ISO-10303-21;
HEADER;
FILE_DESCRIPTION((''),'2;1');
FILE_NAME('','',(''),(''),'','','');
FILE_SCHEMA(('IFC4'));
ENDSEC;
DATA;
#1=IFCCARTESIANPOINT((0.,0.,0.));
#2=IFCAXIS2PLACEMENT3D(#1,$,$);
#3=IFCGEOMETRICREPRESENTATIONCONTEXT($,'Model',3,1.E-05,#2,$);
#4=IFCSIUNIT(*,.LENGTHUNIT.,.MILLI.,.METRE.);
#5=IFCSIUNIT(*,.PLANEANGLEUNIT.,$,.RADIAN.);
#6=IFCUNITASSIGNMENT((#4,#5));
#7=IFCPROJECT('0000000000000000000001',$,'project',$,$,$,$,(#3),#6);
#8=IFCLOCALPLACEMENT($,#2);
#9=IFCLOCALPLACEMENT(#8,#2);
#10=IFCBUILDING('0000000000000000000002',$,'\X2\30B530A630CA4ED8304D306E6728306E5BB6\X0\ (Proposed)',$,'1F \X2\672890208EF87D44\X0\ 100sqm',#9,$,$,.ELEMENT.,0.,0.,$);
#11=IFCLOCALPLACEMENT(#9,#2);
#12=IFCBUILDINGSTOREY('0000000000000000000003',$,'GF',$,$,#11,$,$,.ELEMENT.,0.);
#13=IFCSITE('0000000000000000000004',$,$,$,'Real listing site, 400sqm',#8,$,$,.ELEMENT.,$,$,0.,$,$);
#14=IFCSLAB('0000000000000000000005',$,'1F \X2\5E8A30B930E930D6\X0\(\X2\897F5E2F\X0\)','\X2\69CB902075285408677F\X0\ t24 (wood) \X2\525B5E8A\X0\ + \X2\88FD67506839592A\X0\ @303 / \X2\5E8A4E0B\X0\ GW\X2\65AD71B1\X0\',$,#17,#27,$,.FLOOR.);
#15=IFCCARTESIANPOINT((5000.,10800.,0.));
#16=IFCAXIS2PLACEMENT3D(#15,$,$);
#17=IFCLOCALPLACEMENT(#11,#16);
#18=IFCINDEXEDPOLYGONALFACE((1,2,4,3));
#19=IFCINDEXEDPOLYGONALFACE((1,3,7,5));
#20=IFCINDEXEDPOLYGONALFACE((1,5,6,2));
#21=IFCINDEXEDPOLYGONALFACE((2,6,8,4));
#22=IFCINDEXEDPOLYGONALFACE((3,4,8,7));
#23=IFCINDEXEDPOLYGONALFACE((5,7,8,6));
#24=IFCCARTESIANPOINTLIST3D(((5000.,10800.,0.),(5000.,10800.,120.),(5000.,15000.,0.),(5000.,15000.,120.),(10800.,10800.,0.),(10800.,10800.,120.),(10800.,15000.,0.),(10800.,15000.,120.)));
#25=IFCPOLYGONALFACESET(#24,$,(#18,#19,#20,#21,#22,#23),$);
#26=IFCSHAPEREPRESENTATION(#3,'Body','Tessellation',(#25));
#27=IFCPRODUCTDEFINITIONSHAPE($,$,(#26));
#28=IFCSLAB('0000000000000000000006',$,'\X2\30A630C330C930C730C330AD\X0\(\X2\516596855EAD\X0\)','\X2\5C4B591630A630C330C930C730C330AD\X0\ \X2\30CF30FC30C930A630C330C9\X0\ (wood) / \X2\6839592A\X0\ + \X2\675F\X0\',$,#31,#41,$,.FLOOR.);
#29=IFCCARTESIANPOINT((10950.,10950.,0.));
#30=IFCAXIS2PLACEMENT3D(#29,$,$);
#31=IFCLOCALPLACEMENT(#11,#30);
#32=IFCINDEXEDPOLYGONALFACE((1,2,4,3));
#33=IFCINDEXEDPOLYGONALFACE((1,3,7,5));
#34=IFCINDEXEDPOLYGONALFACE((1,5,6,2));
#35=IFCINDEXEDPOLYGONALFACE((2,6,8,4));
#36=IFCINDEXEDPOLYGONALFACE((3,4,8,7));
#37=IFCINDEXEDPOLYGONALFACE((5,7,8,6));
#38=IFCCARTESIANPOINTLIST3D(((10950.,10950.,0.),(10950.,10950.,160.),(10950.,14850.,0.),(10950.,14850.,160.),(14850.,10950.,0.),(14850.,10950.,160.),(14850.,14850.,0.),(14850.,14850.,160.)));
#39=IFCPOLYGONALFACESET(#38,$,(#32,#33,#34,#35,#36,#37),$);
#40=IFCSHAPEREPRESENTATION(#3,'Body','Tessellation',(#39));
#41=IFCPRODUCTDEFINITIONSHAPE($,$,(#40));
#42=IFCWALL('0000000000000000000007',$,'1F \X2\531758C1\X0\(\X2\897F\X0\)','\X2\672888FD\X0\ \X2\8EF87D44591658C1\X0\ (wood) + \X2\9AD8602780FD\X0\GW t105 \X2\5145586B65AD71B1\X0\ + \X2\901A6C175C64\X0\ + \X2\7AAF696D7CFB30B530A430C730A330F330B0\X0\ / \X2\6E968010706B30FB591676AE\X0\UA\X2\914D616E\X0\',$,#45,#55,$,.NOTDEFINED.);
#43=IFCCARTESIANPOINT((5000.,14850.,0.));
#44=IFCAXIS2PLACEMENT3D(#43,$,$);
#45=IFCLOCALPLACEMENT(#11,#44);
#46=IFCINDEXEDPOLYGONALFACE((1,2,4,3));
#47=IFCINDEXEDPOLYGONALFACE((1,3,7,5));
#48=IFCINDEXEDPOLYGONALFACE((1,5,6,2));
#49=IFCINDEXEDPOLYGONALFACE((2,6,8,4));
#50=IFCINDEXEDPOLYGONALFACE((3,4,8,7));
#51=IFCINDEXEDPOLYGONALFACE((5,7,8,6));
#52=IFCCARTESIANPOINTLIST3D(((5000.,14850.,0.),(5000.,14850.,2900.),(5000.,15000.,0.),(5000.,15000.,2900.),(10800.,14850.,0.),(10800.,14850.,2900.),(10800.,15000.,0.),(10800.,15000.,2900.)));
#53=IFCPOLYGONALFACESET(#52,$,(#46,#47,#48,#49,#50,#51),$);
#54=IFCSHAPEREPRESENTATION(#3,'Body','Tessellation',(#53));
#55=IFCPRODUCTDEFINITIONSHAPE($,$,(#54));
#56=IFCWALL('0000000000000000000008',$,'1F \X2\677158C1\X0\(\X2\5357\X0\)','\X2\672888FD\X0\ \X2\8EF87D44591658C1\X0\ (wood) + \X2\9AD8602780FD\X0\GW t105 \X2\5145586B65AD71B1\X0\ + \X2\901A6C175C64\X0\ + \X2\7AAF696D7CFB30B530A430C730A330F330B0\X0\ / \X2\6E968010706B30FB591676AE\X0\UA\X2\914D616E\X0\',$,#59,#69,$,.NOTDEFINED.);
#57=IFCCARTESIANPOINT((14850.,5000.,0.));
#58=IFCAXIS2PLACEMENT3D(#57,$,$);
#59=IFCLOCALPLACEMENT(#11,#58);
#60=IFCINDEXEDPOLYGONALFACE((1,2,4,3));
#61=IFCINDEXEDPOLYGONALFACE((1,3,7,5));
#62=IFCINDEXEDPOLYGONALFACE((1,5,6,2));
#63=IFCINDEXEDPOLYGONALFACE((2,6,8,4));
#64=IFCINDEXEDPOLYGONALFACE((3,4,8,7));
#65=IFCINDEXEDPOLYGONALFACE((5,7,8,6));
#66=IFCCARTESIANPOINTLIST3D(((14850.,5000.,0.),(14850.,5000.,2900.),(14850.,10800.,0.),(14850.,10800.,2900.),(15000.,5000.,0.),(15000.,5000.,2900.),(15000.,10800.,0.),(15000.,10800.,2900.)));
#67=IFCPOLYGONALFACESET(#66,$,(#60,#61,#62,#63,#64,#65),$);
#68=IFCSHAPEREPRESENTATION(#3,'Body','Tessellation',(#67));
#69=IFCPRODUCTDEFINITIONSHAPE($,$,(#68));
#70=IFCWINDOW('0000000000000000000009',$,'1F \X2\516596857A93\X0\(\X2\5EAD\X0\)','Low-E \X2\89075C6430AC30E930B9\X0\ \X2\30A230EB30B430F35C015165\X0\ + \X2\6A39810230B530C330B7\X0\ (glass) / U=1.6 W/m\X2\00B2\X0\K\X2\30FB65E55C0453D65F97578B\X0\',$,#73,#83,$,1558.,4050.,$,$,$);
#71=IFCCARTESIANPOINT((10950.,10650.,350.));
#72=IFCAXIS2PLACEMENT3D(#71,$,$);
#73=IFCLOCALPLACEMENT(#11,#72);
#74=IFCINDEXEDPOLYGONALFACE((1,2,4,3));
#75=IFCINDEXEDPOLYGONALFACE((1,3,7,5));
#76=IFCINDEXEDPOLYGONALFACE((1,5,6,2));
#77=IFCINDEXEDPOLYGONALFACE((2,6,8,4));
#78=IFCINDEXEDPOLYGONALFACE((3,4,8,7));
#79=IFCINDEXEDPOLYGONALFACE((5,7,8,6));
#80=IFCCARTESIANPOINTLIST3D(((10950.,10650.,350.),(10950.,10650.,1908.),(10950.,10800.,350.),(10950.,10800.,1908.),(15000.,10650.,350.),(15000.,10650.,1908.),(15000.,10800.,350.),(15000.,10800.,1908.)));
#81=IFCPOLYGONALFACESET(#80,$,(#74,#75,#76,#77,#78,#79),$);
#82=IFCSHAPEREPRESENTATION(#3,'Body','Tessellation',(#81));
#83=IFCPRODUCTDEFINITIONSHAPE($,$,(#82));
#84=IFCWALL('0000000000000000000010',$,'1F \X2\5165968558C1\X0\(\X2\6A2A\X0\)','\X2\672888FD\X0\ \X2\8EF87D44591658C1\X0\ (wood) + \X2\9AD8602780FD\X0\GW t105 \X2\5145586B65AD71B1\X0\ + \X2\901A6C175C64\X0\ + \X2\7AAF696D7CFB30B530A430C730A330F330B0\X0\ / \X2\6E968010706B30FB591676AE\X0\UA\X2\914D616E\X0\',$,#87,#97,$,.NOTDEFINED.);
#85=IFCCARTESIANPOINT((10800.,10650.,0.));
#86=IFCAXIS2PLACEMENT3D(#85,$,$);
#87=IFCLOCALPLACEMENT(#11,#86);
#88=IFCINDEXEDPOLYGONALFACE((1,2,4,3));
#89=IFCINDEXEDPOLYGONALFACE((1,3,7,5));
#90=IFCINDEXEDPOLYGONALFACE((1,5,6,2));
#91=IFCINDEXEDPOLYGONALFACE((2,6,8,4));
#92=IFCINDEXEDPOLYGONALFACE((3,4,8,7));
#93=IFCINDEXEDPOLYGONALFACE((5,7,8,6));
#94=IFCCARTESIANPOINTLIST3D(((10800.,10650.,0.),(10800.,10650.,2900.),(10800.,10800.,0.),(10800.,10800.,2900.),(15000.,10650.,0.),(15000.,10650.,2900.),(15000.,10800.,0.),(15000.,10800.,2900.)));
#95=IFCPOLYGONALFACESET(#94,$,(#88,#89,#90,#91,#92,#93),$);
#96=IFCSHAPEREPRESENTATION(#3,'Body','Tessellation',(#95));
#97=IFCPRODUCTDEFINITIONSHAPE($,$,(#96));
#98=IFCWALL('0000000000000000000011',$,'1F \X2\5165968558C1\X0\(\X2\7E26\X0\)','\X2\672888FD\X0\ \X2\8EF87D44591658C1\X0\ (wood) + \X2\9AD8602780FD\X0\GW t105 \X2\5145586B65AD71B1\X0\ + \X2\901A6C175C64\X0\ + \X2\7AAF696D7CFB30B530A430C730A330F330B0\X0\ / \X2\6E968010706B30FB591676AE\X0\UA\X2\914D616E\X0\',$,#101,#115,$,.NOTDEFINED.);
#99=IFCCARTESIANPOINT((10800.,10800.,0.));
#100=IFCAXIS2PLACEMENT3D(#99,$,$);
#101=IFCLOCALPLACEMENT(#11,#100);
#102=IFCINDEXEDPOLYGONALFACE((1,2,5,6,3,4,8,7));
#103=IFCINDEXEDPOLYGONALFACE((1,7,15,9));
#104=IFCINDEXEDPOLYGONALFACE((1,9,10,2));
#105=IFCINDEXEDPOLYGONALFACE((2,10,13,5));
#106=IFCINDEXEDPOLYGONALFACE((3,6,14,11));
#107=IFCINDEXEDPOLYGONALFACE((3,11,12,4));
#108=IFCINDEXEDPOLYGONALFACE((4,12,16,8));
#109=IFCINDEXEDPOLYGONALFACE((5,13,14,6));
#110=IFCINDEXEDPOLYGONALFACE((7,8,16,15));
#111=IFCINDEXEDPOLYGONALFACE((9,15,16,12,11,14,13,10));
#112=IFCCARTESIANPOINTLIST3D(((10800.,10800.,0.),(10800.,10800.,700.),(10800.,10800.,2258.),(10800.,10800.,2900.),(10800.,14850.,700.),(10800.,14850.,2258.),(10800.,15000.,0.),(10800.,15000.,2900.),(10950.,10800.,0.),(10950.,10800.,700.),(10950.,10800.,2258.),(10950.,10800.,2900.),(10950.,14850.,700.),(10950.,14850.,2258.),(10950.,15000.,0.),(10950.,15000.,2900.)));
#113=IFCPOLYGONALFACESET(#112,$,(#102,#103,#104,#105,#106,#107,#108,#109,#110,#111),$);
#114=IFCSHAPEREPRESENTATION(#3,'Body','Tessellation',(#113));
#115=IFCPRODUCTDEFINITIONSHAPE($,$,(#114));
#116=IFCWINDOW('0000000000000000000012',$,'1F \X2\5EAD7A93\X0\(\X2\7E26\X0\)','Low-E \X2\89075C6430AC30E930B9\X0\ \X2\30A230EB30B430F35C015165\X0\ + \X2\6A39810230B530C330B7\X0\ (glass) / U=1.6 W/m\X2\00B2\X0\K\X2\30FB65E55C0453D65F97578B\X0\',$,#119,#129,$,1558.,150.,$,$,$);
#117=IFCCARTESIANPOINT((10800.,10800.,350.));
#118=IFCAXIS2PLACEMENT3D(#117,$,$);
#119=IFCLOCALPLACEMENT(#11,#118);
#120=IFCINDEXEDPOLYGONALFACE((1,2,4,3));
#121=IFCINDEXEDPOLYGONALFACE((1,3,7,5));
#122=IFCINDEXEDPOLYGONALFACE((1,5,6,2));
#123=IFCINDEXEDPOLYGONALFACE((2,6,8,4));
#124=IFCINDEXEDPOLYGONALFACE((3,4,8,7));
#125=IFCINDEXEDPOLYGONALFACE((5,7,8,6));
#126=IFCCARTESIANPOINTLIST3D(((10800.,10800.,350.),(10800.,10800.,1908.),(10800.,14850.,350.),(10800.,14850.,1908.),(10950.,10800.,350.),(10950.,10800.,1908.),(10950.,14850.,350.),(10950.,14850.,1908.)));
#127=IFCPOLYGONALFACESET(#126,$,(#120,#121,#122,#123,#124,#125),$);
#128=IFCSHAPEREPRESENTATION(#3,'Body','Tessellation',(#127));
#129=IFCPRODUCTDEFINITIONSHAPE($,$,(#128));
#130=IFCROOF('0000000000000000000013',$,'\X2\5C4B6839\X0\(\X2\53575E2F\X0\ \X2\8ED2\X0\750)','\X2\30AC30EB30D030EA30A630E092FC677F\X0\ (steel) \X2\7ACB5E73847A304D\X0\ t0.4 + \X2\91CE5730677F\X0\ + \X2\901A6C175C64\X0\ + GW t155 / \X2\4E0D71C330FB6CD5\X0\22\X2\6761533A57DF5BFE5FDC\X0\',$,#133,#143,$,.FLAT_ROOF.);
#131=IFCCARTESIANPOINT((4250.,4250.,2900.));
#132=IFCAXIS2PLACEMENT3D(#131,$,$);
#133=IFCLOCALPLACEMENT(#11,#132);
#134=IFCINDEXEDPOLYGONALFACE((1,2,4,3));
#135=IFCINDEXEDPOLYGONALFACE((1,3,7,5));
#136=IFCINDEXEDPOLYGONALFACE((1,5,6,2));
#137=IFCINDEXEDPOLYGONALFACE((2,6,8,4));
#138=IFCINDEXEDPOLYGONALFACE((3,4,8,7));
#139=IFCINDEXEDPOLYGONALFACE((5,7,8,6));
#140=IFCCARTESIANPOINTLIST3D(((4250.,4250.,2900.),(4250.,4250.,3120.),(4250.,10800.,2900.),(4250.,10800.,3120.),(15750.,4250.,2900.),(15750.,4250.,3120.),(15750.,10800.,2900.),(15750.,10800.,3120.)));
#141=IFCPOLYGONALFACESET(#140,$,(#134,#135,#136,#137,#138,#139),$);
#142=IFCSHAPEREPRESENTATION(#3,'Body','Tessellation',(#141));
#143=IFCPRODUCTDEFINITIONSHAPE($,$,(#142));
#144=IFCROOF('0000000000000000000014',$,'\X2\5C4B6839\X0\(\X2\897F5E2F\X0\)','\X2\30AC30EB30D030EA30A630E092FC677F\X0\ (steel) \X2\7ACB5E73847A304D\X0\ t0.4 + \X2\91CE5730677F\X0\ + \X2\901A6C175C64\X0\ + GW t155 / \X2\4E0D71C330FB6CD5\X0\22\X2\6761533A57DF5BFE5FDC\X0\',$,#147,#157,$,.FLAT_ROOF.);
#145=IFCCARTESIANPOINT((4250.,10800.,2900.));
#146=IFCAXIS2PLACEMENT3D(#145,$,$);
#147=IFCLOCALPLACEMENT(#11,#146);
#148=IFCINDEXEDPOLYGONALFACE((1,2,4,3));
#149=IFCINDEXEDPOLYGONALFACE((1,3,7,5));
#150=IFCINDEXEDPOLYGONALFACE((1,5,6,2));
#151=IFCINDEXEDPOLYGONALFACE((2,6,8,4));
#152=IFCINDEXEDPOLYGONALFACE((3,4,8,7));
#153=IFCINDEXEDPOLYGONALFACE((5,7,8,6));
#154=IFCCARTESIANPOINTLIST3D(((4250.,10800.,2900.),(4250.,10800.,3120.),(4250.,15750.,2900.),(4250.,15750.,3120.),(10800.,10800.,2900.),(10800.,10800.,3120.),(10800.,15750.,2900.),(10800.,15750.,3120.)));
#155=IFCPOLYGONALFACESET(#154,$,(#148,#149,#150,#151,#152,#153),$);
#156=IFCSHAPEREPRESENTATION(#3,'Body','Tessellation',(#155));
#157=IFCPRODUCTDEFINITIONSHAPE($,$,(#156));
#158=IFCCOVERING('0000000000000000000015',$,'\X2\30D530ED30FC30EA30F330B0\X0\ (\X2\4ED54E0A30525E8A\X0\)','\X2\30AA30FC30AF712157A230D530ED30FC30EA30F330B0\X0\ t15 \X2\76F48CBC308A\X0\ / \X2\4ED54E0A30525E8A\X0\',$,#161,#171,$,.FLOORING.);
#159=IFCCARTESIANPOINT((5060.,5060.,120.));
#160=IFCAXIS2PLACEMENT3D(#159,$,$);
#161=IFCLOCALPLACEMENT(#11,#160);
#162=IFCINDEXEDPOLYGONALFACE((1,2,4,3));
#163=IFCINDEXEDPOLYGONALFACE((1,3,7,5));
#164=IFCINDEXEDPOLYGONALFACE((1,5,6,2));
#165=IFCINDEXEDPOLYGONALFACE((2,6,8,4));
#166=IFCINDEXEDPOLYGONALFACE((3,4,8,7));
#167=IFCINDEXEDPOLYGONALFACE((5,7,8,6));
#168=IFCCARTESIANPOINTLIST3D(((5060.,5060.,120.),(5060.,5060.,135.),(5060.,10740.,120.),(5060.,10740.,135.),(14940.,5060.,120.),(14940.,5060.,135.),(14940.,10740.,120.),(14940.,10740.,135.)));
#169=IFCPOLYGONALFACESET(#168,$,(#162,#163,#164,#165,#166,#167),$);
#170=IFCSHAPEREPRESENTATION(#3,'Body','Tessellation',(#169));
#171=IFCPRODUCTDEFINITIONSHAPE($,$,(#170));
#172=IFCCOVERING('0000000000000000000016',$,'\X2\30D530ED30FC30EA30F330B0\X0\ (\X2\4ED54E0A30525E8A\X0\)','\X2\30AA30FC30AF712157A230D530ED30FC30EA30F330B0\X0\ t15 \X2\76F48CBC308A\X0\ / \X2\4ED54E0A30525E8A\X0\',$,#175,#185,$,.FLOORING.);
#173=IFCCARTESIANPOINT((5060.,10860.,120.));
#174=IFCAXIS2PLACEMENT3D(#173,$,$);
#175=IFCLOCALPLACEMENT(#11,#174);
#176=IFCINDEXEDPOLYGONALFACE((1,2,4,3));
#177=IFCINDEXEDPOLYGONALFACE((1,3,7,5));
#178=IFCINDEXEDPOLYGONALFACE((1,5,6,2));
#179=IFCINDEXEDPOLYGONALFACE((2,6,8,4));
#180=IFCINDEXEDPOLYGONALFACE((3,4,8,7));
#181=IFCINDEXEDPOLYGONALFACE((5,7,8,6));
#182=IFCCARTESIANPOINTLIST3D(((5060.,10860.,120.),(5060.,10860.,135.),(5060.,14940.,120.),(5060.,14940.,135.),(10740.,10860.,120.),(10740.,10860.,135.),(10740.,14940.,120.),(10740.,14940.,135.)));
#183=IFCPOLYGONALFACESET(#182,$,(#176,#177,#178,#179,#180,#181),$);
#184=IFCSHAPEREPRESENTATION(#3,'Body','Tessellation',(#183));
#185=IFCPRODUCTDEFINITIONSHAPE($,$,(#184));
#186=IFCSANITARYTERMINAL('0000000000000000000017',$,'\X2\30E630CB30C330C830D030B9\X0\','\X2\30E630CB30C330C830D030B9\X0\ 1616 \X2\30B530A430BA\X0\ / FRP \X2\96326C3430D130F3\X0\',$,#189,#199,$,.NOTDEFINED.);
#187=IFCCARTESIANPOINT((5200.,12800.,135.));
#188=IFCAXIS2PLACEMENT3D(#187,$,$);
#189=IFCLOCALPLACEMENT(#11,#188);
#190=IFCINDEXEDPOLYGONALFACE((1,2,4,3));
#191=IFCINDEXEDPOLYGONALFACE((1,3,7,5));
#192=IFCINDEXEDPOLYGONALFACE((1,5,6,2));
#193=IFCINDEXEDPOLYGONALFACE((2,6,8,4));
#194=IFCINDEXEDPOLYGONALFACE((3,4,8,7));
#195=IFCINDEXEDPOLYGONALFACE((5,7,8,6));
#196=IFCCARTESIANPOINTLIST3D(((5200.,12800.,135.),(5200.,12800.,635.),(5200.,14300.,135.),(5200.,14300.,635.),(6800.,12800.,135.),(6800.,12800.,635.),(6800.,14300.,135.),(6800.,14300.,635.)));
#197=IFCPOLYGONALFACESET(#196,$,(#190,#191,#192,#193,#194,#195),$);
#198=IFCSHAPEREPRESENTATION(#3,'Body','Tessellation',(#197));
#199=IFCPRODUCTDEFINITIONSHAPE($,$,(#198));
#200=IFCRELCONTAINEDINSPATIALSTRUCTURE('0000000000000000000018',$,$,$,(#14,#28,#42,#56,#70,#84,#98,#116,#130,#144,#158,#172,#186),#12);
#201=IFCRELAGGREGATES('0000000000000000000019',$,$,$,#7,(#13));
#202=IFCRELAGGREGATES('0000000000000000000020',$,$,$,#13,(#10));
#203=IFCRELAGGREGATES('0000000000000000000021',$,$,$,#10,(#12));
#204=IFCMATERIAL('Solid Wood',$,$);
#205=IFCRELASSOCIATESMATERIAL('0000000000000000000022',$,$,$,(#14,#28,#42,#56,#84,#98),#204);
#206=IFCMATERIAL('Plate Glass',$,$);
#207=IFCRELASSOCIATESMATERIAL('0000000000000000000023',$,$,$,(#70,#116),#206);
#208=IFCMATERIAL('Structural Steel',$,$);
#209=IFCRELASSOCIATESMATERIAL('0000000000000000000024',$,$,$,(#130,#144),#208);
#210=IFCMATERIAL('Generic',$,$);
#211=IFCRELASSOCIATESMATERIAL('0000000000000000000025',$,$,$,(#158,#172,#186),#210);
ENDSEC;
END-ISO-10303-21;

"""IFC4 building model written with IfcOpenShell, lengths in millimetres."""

from ifc_helpers import new_model, si_unit, frame, frame_2d, origin, place, context, project, spatial, rectangle, extrude, material, element, fill, save


model = new_model("IFC4")

# Units and contexts
model_context = context("Model", 3, precision=1e-05, world=origin())
ifc_project = project(units=[si_unit("LENGTHUNIT", "METRE", prefix="MILLI"), si_unit("PLANEANGLEUNIT", "RADIAN")], contexts=[model_context])

# Site, building, storey
site_placement = place(None, origin())
site = spatial("IfcSite", under=ifc_project, at=site_placement, ObjectType="Real listing site, 400sqm", CompositionType="ELEMENT", RefElevation=0.0)
building_placement = place(site_placement, origin())
building = spatial("IfcBuilding", under=site, at=building_placement, Name="サウナ付きの木の家 (Proposed)", ObjectType="1F 木造軸組 100sqm", CompositionType="ELEMENT", ElevationOfRefHeight=0.0, ElevationOfTerrain=0.0)
storey_placement = place(building_placement, origin())
storey = spatial("IfcBuildingStorey", under=building, at=storey_placement, Name="GF", CompositionType="ELEMENT", Elevation=0.0)

# Slabs
ifc_material_1 = material(Name="Solid Wood")
slab_1_placement = place(storey_placement, frame((5000.0, 10800.0, 0.0)))
element("IfcSlab", 1, at=slab_1_placement, inside=storey, material=ifc_material_1, Name="1F 床スラブ(西帯)", Description="構造用合板 t24 (wood) 剛床 + 製材根太 @303 / 床下 GW断熱", PredefinedType="FLOOR", context=model_context, shape_type="SweptSolid", body=[
    extrude(rectangle(XDim=5800.0, YDim=4200.0, at=frame_2d((2900.0, 2100.0))), frame((5000.0, 10800.0, 0.0)), (0.0, 0.0, 1.0), 120.0),
])
slab_2_placement = place(storey_placement, frame((10950.0, 10950.0, 0.0)))
element("IfcSlab", 2, at=slab_2_placement, inside=storey, material=ifc_material_1, Name="ウッドデッキ(入隅庭)", Description="屋外ウッドデッキ ハードウッド (wood) / 根太 + 束", PredefinedType="FLOOR", context=model_context, shape_type="SweptSolid", body=[
    extrude(rectangle(XDim=3900.0, YDim=3900.0, at=frame_2d((1950.0, 1950.0))), frame((10950.0, 10950.0, 0.0)), (0.0, 0.0, 1.0), 160.0),
])

# Shared definitions
ifc_material_2 = material(Name="Plate Glass")

# Wall
wall_1_placement = place(storey_placement, frame((5000.0, 14850.0, 0.0)))
element("IfcWall", 3, at=wall_1_placement, inside=storey, material=ifc_material_1, Name="1F 北壁(西)", Description="木製 軸組外壁 (wood) + 高性能GW t105 充填断熱 + 通気層 + 窯業系サイディング / 準耐火・外皮UA配慮", PredefinedType="NOTDEFINED", context=model_context, shape_type="SweptSolid", body=[
    extrude(rectangle(XDim=5800.0, YDim=150.0, at=frame_2d((2900.0, 75.0))), frame((5000.0, 14850.0, 0.0)), (0.0, 0.0, 1.0), 2900.0),
])

# Wall, opening, window
wall_2_placement = place(storey_placement, frame((14850.0, 5000.0, 0.0)))
wall_2 = element("IfcWall", 4, at=wall_2_placement, inside=storey, material=ifc_material_1, Name="1F 東壁(南)", Description="木製 軸組外壁 (wood) + 高性能GW t105 充填断熱 + 通気層 + 窯業系サイディング / 準耐火・外皮UA配慮", PredefinedType="NOTDEFINED", context=model_context, shape_type="SweptSolid", body=[
    extrude(rectangle(XDim=150.0, YDim=5800.0, at=frame_2d((75.0, 2900.0))), frame((14850.0, 5000.0, 0.0)), (0.0, 0.0, 1.0), 2900.0),
])
opening_1_placement = place(storey_placement, frame((10950.0, 10650.0, 350.0)))
opening_1 = element("IfcOpeningElement", 5, at=opening_1_placement, cuts=wall_2, PredefinedType="NOTDEFINED", context=model_context, shape_type="SweptSolid", body=[
    extrude(rectangle(XDim=4050.0, YDim=150.0, at=frame_2d((2025.0, 75.0))), frame((10950.0, 10650.0, 350.0)), (0.0, 0.0, 1.0), 1558.0),
])
window_1_placement = place(storey_placement, frame((10950.0, 10650.0, 350.0)))
window_1 = element("IfcWindow", 6, at=window_1_placement, inside=storey, material=ifc_material_2, Name="1F 入隅窓(庭)", Description="Low-E 複層ガラス アルゴン封入 + 樹脂サッシ (glass) / U=1.6 W/m²K・日射取得型", OverallHeight=1558.0, OverallWidth=4050.0, context=model_context, shape_type="SweptSolid", body=[
    extrude(rectangle(XDim=4050.0, YDim=150.0, at=frame_2d((2025.0, 75.0))), frame((10950.0, 10650.0, 350.0)), (0.0, 0.0, 1.0), 1558.0),
])
fill(opening_1, window_1)

# Wall
wall_3_placement = place(storey_placement, frame((10800.0, 10650.0, 0.0)))
element("IfcWall", 7, at=wall_3_placement, inside=storey, material=ifc_material_1, Name="1F 入隅壁(横)", Description="木製 軸組外壁 (wood) + 高性能GW t105 充填断熱 + 通気層 + 窯業系サイディング / 準耐火・外皮UA配慮", PredefinedType="NOTDEFINED", context=model_context, shape_type="SweptSolid", body=[
    extrude(rectangle(XDim=4200.0, YDim=150.0, at=frame_2d((2100.0, 75.0))), frame((10800.0, 10650.0, 0.0)), (0.0, 0.0, 1.0), 2900.0),
])

# Wall, opening, window
wall_4_placement = place(storey_placement, frame((10800.0, 10800.0, 0.0)))
wall_4 = element("IfcWall", 8, at=wall_4_placement, inside=storey, material=ifc_material_1, Name="1F 入隅壁(縦)", Description="木製 軸組外壁 (wood) + 高性能GW t105 充填断熱 + 通気層 + 窯業系サイディング / 準耐火・外皮UA配慮", PredefinedType="NOTDEFINED", context=model_context, shape_type="SweptSolid", body=[
    extrude(rectangle(XDim=150.0, YDim=4200.0, at=frame_2d((75.0, 2100.0))), frame((10800.0, 10800.0, 0.0)), (0.0, 0.0, 1.0), 2900.0),
])
opening_2_placement = place(storey_placement, frame((10800.0, 10800.0, 350.0)))
opening_2 = element("IfcOpeningElement", 9, at=opening_2_placement, cuts=wall_4, PredefinedType="NOTDEFINED", context=model_context, shape_type="SweptSolid", body=[
    extrude(rectangle(XDim=150.0, YDim=4050.0, at=frame_2d((75.0, 2025.0))), frame((10800.0, 10800.0, 350.0)), (0.0, 0.0, 1.0), 1558.0),
])
window_2_placement = place(storey_placement, frame((10800.0, 10800.0, 350.0)))
window_2 = element("IfcWindow", 10, at=window_2_placement, inside=storey, material=ifc_material_2, Name="1F 庭窓(縦)", Description="Low-E 複層ガラス アルゴン封入 + 樹脂サッシ (glass) / U=1.6 W/m²K・日射取得型", OverallHeight=1558.0, OverallWidth=150.0, context=model_context, shape_type="SweptSolid", body=[
    extrude(rectangle(XDim=150.0, YDim=4050.0, at=frame_2d((75.0, 2025.0))), frame((10800.0, 10800.0, 350.0)), (0.0, 0.0, 1.0), 1558.0),
])
fill(opening_2, window_2)

# Roofs
ifc_material_3 = material(Name="Structural Steel")
roof_1_placement = place(storey_placement, frame((4250.0, 4250.0, 2900.0)))
element("IfcRoof", 11, at=roof_1_placement, inside=storey, material=ifc_material_3, Name="屋根(南帯 軒750)", Description="ガルバリウム鋼板 (steel) 立平葺き t0.4 + 野地板 + 通気層 + GW t155 / 不燃・法22条区域対応", PredefinedType="FLAT_ROOF", context=model_context, shape_type="SweptSolid", body=[
    extrude(rectangle(XDim=11500.0, YDim=6550.0, at=frame_2d((5750.0, 3275.0))), frame((4250.0, 4250.0, 2900.0)), (0.0, 0.0, 1.0), 220.0),
])
roof_2_placement = place(storey_placement, frame((4250.0, 10800.0, 2900.0)))
element("IfcRoof", 12, at=roof_2_placement, inside=storey, material=ifc_material_3, Name="屋根(西帯)", Description="ガルバリウム鋼板 (steel) 立平葺き t0.4 + 野地板 + 通気層 + GW t155 / 不燃・法22条区域対応", PredefinedType="FLAT_ROOF", context=model_context, shape_type="SweptSolid", body=[
    extrude(rectangle(XDim=6550.0, YDim=4950.0, at=frame_2d((3275.0, 2475.0))), frame((4250.0, 10800.0, 2900.0)), (0.0, 0.0, 1.0), 220.0),
])

# Coverings
ifc_material_4 = material(Name="Generic")
covering_1_placement = place(storey_placement, frame((5060.0, 5060.0, 120.0)))
element("IfcCovering", 13, at=covering_1_placement, inside=storey, material=ifc_material_4, Name="フローリング (仕上げ床)", Description="オーク無垢フローリング t15 直貼り / 仕上げ床", PredefinedType="FLOORING", context=model_context, shape_type="SweptSolid", body=[
    extrude(rectangle(XDim=9880.0, YDim=5680.0, at=frame_2d((4940.0, 2840.0))), frame((5060.0, 5060.0, 120.0)), (0.0, 0.0, 1.0), 15.0),
])
covering_2_placement = place(storey_placement, frame((5060.0, 10860.0, 120.0)))
element("IfcCovering", 14, at=covering_2_placement, inside=storey, material=ifc_material_4, Name="フローリング (仕上げ床)", Description="オーク無垢フローリング t15 直貼り / 仕上げ床", PredefinedType="FLOORING", context=model_context, shape_type="SweptSolid", body=[
    extrude(rectangle(XDim=5680.0, YDim=4080.0, at=frame_2d((2840.0, 2040.0))), frame((5060.0, 10860.0, 120.0)), (0.0, 0.0, 1.0), 15.0),
])

# Sanitary terminal
sanitary_terminal_1_placement = place(storey_placement, frame((5200.0, 12800.0, 135.0)))
element("IfcSanitaryTerminal", 15, at=sanitary_terminal_1_placement, inside=storey, material=ifc_material_4, Name="ユニットバス", Description="ユニットバス 1616 サイズ / FRP 防水パン", PredefinedType="NOTDEFINED", context=model_context, shape_type="SweptSolid", body=[
    extrude(rectangle(XDim=1600.0, YDim=1500.0, at=frame_2d((800.0, 750.0))), frame((5200.0, 12800.0, 135.0)), (0.0, 0.0, 1.0), 500.0),
])

save(model, "model.ifc")
